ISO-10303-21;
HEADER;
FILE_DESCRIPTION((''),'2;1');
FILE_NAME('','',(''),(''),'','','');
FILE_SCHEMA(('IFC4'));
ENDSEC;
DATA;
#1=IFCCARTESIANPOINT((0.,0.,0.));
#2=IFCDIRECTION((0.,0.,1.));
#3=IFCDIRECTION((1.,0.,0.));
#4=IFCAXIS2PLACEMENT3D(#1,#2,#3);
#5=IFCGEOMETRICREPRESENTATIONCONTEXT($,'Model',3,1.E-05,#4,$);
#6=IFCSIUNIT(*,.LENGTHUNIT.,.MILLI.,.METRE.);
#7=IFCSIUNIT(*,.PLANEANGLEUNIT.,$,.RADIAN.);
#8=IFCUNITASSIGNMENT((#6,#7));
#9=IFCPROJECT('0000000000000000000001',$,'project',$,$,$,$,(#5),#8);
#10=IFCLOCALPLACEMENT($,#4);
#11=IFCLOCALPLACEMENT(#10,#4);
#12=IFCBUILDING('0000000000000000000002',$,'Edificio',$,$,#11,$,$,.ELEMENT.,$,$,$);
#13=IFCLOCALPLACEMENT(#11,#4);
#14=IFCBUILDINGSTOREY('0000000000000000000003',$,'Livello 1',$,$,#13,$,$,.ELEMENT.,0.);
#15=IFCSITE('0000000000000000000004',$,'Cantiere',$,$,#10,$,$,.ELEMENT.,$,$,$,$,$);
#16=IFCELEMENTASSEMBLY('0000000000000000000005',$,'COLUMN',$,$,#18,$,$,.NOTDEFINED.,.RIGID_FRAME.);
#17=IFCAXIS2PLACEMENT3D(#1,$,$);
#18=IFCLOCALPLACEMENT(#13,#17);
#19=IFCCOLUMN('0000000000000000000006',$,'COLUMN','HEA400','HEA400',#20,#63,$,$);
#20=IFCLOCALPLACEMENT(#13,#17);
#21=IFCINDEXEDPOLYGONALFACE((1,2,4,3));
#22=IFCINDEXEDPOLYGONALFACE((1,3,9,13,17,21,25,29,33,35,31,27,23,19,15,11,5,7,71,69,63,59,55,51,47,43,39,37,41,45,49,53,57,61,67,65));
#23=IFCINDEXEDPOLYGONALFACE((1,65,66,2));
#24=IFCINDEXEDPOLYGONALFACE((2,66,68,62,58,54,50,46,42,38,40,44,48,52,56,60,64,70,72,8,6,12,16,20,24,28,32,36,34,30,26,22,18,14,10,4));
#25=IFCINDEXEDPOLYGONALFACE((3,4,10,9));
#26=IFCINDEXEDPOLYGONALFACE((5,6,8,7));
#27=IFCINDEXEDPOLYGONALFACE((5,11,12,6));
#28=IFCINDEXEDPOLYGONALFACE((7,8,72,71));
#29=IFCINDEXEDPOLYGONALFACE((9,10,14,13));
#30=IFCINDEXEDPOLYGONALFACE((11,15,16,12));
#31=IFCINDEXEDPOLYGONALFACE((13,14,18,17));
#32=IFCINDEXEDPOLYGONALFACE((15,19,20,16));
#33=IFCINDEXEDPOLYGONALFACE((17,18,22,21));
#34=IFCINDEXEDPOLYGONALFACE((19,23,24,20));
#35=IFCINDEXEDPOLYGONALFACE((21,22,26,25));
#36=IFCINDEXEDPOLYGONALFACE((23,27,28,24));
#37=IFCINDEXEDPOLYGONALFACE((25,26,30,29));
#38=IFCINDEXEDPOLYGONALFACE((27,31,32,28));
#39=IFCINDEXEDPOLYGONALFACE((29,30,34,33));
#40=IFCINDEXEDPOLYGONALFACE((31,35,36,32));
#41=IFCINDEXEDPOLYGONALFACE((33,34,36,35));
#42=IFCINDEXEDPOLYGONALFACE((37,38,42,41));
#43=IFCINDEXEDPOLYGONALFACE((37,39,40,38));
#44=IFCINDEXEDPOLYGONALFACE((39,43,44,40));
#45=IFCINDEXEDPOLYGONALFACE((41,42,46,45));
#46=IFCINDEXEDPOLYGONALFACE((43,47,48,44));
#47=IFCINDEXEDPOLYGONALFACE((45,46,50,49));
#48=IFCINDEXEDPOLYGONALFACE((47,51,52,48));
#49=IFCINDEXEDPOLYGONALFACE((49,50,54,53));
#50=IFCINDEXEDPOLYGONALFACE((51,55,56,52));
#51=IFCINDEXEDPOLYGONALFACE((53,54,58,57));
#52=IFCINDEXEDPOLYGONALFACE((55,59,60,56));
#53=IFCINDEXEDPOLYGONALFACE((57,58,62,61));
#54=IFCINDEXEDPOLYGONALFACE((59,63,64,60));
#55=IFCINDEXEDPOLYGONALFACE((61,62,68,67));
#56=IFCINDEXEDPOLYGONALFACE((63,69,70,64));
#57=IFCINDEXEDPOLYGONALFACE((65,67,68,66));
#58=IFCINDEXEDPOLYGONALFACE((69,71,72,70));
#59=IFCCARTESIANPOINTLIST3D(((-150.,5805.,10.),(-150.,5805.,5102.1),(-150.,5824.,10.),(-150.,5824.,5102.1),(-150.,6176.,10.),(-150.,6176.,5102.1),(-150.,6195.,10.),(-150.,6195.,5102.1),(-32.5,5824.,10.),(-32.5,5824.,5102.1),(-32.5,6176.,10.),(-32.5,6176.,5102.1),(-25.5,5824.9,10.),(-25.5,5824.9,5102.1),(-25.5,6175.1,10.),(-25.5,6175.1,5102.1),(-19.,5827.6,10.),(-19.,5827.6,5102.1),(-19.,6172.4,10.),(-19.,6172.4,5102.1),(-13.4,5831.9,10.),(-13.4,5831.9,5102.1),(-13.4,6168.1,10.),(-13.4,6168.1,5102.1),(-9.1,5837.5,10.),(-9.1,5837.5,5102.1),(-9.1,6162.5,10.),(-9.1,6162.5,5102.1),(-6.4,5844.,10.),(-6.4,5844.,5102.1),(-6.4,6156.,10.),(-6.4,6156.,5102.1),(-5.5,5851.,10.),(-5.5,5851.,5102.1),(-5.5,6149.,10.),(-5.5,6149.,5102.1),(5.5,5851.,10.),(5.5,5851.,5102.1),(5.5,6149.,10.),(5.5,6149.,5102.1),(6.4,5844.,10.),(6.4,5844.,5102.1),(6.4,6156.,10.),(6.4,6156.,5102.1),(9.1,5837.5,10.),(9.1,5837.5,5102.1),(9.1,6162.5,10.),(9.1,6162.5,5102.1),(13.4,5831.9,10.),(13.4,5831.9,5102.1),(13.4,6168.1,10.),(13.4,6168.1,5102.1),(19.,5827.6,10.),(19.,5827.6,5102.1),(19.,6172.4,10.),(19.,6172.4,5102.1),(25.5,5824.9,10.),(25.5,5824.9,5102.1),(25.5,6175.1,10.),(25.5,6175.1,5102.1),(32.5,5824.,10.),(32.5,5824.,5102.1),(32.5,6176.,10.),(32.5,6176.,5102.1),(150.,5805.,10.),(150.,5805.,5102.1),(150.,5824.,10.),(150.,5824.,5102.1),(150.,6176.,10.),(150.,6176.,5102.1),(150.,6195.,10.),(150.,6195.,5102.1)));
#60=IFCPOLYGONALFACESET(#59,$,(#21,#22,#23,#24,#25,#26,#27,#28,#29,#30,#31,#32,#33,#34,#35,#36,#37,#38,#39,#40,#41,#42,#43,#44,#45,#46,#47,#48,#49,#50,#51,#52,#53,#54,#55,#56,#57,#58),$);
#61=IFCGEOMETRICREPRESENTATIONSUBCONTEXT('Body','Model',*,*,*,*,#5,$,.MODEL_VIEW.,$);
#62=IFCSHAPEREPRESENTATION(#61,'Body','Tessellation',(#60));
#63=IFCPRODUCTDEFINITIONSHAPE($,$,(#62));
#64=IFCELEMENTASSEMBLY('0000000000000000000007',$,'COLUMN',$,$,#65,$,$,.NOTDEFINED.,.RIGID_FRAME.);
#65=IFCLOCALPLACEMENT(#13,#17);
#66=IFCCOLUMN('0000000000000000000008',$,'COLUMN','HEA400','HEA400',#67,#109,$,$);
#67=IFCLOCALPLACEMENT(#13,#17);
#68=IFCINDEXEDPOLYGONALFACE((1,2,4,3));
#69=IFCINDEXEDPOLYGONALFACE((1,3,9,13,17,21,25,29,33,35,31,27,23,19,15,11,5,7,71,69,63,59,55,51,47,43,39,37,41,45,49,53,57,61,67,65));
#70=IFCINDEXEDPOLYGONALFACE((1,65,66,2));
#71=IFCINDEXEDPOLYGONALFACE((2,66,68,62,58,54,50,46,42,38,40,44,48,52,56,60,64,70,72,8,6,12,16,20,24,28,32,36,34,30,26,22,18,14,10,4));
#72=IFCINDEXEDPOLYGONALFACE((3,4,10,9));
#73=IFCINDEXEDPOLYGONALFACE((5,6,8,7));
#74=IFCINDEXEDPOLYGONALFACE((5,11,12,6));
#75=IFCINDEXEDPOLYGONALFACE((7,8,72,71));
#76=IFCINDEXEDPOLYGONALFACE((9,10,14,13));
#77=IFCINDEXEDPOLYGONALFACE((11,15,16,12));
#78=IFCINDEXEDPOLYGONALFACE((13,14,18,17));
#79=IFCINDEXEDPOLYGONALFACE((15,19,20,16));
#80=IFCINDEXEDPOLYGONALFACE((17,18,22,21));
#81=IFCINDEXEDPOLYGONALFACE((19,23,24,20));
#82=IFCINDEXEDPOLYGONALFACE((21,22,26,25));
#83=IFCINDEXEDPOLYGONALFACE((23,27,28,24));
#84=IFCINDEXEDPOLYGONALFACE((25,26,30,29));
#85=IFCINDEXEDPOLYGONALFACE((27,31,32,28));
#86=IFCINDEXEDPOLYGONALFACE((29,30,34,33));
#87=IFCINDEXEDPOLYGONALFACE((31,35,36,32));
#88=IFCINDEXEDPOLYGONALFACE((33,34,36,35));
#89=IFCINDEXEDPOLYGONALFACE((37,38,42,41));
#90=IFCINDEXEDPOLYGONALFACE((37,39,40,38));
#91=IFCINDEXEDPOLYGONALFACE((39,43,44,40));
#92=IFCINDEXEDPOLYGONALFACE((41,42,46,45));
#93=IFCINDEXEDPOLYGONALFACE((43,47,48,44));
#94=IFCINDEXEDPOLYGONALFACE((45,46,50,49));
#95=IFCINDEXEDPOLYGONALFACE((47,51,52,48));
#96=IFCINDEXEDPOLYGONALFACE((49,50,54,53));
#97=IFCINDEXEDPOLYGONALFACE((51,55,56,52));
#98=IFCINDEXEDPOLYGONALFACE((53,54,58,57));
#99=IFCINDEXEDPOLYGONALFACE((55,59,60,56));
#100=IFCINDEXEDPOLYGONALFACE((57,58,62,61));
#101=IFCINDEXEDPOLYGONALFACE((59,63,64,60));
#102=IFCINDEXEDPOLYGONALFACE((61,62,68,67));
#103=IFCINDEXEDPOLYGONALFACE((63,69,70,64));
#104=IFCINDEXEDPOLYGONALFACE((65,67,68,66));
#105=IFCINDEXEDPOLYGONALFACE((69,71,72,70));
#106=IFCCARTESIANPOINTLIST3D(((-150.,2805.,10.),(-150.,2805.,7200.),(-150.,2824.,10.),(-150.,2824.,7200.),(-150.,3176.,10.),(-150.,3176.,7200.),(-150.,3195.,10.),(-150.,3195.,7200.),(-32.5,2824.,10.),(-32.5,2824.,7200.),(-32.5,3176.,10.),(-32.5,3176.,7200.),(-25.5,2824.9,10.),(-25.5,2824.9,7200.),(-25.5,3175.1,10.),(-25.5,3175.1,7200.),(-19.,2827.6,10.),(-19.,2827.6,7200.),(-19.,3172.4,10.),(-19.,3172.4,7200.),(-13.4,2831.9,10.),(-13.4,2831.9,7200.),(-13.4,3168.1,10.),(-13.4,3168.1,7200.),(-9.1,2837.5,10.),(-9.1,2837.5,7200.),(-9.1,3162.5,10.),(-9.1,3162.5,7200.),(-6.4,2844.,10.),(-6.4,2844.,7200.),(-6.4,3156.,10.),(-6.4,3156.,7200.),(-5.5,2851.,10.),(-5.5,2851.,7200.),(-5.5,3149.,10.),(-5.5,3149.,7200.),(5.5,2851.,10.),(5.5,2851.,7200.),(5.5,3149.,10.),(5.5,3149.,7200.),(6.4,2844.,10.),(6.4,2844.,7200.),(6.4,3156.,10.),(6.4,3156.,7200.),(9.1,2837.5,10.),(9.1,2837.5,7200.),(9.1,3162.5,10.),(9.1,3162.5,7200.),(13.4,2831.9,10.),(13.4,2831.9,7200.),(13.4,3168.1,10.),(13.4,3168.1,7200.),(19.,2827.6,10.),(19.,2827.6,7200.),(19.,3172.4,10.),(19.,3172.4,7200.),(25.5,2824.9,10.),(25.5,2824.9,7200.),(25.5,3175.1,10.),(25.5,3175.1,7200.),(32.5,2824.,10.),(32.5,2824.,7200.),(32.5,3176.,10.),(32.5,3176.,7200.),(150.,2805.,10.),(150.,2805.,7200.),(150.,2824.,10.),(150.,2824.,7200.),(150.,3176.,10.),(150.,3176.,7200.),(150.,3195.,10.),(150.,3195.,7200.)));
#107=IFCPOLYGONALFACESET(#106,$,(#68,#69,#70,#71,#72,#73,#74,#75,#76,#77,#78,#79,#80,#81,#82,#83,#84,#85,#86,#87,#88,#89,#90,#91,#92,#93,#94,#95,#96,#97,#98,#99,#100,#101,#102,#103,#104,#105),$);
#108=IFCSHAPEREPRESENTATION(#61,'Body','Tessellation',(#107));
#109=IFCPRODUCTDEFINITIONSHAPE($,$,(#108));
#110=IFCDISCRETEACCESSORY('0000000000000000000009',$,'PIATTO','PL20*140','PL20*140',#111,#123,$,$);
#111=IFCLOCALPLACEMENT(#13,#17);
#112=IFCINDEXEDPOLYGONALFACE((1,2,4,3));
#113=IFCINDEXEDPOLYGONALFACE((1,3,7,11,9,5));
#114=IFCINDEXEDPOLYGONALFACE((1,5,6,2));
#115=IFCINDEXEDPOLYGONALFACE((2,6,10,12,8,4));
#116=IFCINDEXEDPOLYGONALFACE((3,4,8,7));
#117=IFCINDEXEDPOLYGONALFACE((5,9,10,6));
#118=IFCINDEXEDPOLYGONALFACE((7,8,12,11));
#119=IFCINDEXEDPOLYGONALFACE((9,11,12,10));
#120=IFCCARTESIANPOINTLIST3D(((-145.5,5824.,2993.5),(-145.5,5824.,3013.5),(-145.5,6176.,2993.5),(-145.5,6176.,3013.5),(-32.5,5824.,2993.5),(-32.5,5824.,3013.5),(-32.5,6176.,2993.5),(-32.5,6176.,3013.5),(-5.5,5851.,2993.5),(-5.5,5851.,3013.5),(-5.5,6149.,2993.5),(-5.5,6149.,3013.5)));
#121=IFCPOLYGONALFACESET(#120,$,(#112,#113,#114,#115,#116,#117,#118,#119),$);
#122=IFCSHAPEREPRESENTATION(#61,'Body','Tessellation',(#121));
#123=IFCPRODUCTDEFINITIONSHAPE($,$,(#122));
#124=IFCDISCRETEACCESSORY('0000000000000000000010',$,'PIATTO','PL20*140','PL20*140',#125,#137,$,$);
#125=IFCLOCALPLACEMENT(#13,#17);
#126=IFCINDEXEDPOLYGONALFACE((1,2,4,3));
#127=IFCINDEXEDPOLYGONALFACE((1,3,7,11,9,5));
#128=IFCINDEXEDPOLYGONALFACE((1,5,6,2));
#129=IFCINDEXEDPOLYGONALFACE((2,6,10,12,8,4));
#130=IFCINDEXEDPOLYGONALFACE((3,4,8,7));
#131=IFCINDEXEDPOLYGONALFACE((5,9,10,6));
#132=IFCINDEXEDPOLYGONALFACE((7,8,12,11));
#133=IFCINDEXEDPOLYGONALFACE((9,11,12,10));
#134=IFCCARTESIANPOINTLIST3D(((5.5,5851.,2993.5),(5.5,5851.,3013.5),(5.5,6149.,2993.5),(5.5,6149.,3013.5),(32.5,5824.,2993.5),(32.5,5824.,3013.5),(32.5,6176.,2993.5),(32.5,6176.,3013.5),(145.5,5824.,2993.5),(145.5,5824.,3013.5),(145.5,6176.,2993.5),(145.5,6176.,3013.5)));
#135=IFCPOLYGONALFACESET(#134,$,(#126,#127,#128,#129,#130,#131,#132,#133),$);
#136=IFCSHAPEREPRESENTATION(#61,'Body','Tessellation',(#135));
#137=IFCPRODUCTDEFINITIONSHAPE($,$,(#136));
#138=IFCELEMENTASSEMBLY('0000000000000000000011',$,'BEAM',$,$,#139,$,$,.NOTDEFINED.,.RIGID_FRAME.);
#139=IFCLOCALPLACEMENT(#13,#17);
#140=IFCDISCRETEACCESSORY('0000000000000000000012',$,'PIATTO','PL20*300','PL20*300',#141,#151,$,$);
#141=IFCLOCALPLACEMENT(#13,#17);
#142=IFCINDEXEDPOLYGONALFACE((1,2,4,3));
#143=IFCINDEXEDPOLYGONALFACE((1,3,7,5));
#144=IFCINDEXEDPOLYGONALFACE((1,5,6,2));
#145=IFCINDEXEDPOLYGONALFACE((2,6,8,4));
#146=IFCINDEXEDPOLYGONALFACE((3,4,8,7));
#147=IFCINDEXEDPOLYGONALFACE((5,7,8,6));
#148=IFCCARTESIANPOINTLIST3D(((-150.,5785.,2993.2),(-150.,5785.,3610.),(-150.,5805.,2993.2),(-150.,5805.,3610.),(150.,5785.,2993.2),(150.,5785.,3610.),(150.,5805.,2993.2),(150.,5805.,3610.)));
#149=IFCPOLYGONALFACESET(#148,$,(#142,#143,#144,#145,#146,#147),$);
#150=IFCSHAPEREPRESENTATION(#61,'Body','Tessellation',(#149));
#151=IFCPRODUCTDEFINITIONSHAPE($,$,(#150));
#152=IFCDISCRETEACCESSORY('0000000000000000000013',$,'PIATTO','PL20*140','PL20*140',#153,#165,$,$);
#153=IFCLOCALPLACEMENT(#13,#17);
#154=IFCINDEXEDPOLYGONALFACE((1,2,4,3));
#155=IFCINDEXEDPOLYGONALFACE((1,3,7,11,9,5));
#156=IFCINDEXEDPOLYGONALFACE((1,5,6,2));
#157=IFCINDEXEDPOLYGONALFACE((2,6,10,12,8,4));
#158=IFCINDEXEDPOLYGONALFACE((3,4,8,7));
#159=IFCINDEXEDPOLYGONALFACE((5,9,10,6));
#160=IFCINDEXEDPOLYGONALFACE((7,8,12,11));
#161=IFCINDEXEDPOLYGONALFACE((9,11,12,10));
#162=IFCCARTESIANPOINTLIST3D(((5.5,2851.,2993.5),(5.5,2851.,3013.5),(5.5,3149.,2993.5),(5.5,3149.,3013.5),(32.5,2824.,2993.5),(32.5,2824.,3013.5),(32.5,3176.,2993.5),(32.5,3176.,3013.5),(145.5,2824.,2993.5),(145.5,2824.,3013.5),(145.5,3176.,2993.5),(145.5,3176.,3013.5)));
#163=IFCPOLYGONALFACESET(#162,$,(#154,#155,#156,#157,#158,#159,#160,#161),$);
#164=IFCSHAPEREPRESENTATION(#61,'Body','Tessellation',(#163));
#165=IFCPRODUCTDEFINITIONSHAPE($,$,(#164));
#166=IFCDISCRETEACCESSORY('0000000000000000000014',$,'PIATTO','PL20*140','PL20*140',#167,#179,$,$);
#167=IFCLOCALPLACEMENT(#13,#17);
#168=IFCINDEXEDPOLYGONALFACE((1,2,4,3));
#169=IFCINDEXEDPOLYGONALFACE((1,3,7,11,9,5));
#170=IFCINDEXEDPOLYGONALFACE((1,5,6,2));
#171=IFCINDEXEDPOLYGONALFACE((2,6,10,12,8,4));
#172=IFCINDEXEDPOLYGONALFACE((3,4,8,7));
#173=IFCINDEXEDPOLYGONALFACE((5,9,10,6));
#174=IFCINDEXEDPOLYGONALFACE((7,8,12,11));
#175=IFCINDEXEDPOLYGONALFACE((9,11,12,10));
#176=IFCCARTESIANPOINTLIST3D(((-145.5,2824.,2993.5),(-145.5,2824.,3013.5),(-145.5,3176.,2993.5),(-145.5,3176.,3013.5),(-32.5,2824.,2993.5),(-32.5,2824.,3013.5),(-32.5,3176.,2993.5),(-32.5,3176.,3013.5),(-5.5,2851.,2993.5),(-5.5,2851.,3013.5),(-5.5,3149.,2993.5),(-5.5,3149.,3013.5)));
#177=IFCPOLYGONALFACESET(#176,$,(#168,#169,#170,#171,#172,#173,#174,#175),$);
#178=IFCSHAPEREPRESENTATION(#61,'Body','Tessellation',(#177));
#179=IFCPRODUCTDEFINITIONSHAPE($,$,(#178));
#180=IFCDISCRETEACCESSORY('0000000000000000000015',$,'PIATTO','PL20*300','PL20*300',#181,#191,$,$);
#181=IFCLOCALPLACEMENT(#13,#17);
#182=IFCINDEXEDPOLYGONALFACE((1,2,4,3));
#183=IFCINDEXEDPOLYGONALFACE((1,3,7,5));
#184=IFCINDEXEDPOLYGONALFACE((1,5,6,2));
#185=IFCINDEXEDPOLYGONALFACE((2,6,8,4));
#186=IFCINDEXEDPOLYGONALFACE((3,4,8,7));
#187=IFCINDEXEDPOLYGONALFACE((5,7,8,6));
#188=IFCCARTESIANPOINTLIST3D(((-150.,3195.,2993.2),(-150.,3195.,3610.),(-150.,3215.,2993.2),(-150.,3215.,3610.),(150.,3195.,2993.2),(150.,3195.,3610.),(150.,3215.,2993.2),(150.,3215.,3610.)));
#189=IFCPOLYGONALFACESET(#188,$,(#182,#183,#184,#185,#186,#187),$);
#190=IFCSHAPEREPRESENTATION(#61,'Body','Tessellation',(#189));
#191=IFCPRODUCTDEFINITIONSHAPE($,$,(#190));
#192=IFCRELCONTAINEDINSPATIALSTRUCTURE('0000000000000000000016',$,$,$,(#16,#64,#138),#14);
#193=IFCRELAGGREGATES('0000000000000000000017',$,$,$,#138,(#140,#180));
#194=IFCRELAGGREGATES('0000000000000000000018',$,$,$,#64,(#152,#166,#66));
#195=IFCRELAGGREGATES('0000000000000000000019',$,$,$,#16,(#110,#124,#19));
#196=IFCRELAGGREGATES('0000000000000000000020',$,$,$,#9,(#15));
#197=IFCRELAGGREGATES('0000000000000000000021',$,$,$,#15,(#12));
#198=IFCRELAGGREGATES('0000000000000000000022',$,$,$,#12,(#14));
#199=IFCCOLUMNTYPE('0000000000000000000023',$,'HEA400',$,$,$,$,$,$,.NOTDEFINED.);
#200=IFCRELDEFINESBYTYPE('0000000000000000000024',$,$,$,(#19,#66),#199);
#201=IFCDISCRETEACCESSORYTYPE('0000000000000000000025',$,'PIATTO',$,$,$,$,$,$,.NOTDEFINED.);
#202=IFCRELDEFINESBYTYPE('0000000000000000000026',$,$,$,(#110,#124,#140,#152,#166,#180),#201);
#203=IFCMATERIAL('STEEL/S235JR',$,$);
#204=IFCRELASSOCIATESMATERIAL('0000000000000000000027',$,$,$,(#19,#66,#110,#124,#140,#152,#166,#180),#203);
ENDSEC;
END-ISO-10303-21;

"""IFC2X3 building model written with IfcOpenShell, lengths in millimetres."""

from ifc_helpers import new_model, si_unit, frame, origin_with_axes, origin_2d_with_axis, place, context, subcontext, project, spatial, polyline, i_section, outline, extrude, clip, halfspace, material, type_object, element, aggregate, save


model = new_model("IFC2X3")

# Units and contexts
model_context = context("Model", 3, precision=1e-05, world=origin_with_axes())
body_context = subcontext(model_context, "Body", "Model", "MODEL_VIEW")
ifc_project = project(units=[si_unit("LENGTHUNIT", "METRE", prefix="MILLI"), si_unit("PLANEANGLEUNIT", "RADIAN")], contexts=[model_context])

# Site, building, storey
site_placement = place(None, origin_with_axes())
site = spatial("IfcSite", under=ifc_project, at=site_placement, Name="Cantiere", CompositionType="ELEMENT")
building_placement = place(site_placement, origin_with_axes())
building = spatial("IfcBuilding", under=site, at=building_placement, Name="Edificio", CompositionType="ELEMENT")
storey_placement = place(building_placement, origin_with_axes())
storey = spatial("IfcBuildingStorey", under=building, at=storey_placement, Name="Livello 1", CompositionType="ELEMENT", Elevation=0.0)

# Element assemblies, columns
assembly_1_placement = place(storey_placement, origin_with_axes())
assembly_1 = element("IfcElementAssembly", 1, at=assembly_1_placement, inside=storey, Name="COLUMN", AssemblyPlace="NOTDEFINED", PredefinedType="RIGID_FRAME")
ifc_material_1 = material(Name="STEEL/S235JR")
column_type = type_object("IfcColumnType", Name="HEA400", PredefinedType="NOTDEFINED")
column_1_placement = place(assembly_1_placement, frame((0.0, 6000.0, 0.0), z_axis=(0.0, 0.0, 1.0), x_axis=(0.0, 1.0, 0.0)))
column_1 = element("IfcColumn", 2, at=column_1_placement, type_object=column_type, material=ifc_material_1, Name="COLUMN", Description="HEA400", ObjectType="HEA400", context=body_context, shape_type="Clipping", body=[
    clip(clip(extrude(i_section(OverallWidth=300.0, OverallDepth=390.0, WebThickness=11.0, FlangeThickness=19.0, FilletRadius=27.0, at=origin_2d_with_axis()), frame((0.0, 0.0, 5102.1), z_axis=(0.0, 0.0, -1.0), x_axis=(0.0, 1.0, 0.0)), (0.0, 0.0, 1.0), 5092.1), halfspace(frame((-1000.0, 0.0, 5102.1), z_axis=(0.0, 0.0, 1.0), x_axis=(0.0, 1.0, 0.0)), False)), halfspace(frame((-195.0, 0.0, 10.0), z_axis=(0.0, 0.0, 1.0), x_axis=(0.0, 1.0, 0.0)), True)),
])
assembly_2_placement = place(storey_placement, origin_with_axes())
assembly_2 = element("IfcElementAssembly", 3, at=assembly_2_placement, inside=storey, Name="COLUMN", AssemblyPlace="NOTDEFINED", PredefinedType="RIGID_FRAME")
column_2_placement = place(assembly_2_placement, frame((0.0, 3000.0, 0.0), z_axis=(0.0, 0.0, 1.0), x_axis=(0.0, 1.0, 0.0)))
column_2 = element("IfcColumn", 4, at=column_2_placement, type_object=column_type, material=ifc_material_1, Name="COLUMN", Description="HEA400", ObjectType="HEA400", context=body_context, shape_type="Clipping", body=[
    clip(extrude(i_section(OverallWidth=300.0, OverallDepth=390.0, WebThickness=11.0, FlangeThickness=19.0, FilletRadius=27.0, at=origin_2d_with_axis()), frame((0.0, 0.0, 7200.0), z_axis=(0.0, 0.0, -1.0), x_axis=(0.0, 1.0, 0.0)), (0.0, 0.0, 1.0), 7190.0), halfspace(frame((-195.0, 0.0, 10.0), z_axis=(0.0, 0.0, 1.0), x_axis=(0.0, 1.0, 0.0)), True)),
])

# Discrete accessories
discrete_accessory_type_1 = type_object("IfcDiscreteAccessoryType", Name="PIATTO")
discrete_accessory_1_placement = place(assembly_1_placement, frame((-145.5, 5824.0, 3003.5), z_axis=(0.0, 0.0, 1.0), x_axis=(1.0, 0.0, 0.0)))
discrete_accessory_1 = element("IfcDiscreteAccessory", 5, at=discrete_accessory_1_placement, type_object=discrete_accessory_type_1, material=ifc_material_1, Name="PIATTO", Description="PL20*140", ObjectType="PL20*140", context=body_context, shape_type="SweptSolid", body=[
    extrude(outline(polyline([(0.0, 0.0), (113.0, 0.0), (140.0, 27.0), (140.0, 325.0), (113.0, 352.0), (0.0, 352.0), (0.0, 0.0)])), frame((0.0, 0.0, -10.0), z_axis=(0.0, 0.0, 1.0), x_axis=(1.0, 0.0, 0.0)), (0.0, 0.0, 1.0), 20.0),
])
discrete_accessory_2_placement = place(assembly_1_placement, frame((145.5, 5824.0, 3003.5), z_axis=(0.0, 0.0, -1.0), x_axis=(-1.0, 0.0, 0.0)))
discrete_accessory_2 = element("IfcDiscreteAccessory", 6, at=discrete_accessory_2_placement, type_object=discrete_accessory_type_1, material=ifc_material_1, Name="PIATTO", Description="PL20*140", ObjectType="PL20*140", context=body_context, shape_type="SweptSolid", body=[
    extrude(outline(polyline([(0.0, 0.0), (113.0, 0.0), (140.0, 27.0), (140.0, 325.0), (113.0, 352.0), (0.0, 352.0), (0.0, 0.0)])), frame((0.0, 0.0, -10.0), z_axis=(0.0, 0.0, 1.0), x_axis=(1.0, 0.0, 0.0)), (0.0, 0.0, 1.0), 20.0),
])

# Element assembly, discrete accessory
assembly_3_placement = place(storey_placement, origin_with_axes())
assembly_3 = element("IfcElementAssembly", 7, at=assembly_3_placement, inside=storey, Name="BEAM", AssemblyPlace="NOTDEFINED", PredefinedType="RIGID_FRAME")
discrete_accessory_3_placement = place(assembly_3_placement, frame((0.0, 5795.0, 2993.2), z_axis=(0.0, -1.0, 0.0), x_axis=(0.0, 0.0, 1.0)))
discrete_accessory_3 = element("IfcDiscreteAccessory", 8, at=discrete_accessory_3_placement, type_object=discrete_accessory_type_1, material=ifc_material_1, Name="PIATTO", Description="PL20*300", ObjectType="PL20*300", context=body_context, shape_type="SweptSolid", body=[
    extrude(outline(polyline([(0.0, 150.0), (616.8, 150.0), (616.8, -150.0), (0.0, -150.0), (0.0, 150.0)])), frame((0.0, 0.0, -10.0), z_axis=(0.0, 0.0, 1.0), x_axis=(1.0, 0.0, 0.0)), (0.0, 0.0, 1.0), 20.0),
])

# Discrete accessories
discrete_accessory_4_placement = place(assembly_2_placement, frame((145.5, 3176.0, 3003.5), z_axis=(0.0, 0.0, 1.0), x_axis=(-1.0, 0.0, 0.0)))
discrete_accessory_4 = element("IfcDiscreteAccessory", 9, at=discrete_accessory_4_placement, type_object=discrete_accessory_type_1, material=ifc_material_1, Name="PIATTO", Description="PL20*140", ObjectType="PL20*140", context=body_context, shape_type="SweptSolid", body=[
    extrude(outline(polyline([(0.0, 0.0), (113.0, 0.0), (140.0, 27.0), (140.0, 325.0), (113.0, 352.0), (0.0, 352.0), (0.0, 0.0)])), frame((0.0, 0.0, -10.0), z_axis=(0.0, 0.0, 1.0), x_axis=(1.0, 0.0, 0.0)), (0.0, 0.0, 1.0), 20.0),
])
discrete_accessory_5_placement = place(assembly_2_placement, frame((-145.5, 3176.0, 3003.5), z_axis=(0.0, 0.0, -1.0), x_axis=(1.0, 0.0, 0.0)))
discrete_accessory_5 = element("IfcDiscreteAccessory", 10, at=discrete_accessory_5_placement, type_object=discrete_accessory_type_1, material=ifc_material_1, Name="PIATTO", Description="PL20*140", ObjectType="PL20*140", context=body_context, shape_type="SweptSolid", body=[
    extrude(outline(polyline([(0.0, 0.0), (113.0, 0.0), (140.0, 27.0), (140.0, 325.0), (113.0, 352.0), (0.0, 352.0), (0.0, 0.0)])), frame((0.0, 0.0, -10.0), z_axis=(0.0, 0.0, 1.0), x_axis=(1.0, 0.0, 0.0)), (0.0, 0.0, 1.0), 20.0),
])
discrete_accessory_6_placement = place(assembly_3_placement, frame((0.0, 3205.0, 2993.2), z_axis=(0.0, 1.0, 0.0), x_axis=(0.0, 0.0, 1.0)))
discrete_accessory_6 = element("IfcDiscreteAccessory", 11, at=discrete_accessory_6_placement, type_object=discrete_accessory_type_1, material=ifc_material_1, Name="PIATTO", Description="PL20*300", ObjectType="PL20*300", context=body_context, shape_type="SweptSolid", body=[
    extrude(outline(polyline([(0.0, -150.0), (0.0, 150.0), (616.8, 150.0), (616.8, -150.0), (0.0, -150.0)])), frame((0.0, 0.0, -10.0), z_axis=(0.0, 0.0, 1.0), x_axis=(1.0, 0.0, 0.0)), (0.0, 0.0, 1.0), 20.0),
])

aggregate(assembly_3, [discrete_accessory_3, discrete_accessory_6])
aggregate(assembly_2, [discrete_accessory_4, discrete_accessory_5, column_2])

aggregate(assembly_1, [discrete_accessory_1, discrete_accessory_2, column_1])

save(model, "model.ifc")
